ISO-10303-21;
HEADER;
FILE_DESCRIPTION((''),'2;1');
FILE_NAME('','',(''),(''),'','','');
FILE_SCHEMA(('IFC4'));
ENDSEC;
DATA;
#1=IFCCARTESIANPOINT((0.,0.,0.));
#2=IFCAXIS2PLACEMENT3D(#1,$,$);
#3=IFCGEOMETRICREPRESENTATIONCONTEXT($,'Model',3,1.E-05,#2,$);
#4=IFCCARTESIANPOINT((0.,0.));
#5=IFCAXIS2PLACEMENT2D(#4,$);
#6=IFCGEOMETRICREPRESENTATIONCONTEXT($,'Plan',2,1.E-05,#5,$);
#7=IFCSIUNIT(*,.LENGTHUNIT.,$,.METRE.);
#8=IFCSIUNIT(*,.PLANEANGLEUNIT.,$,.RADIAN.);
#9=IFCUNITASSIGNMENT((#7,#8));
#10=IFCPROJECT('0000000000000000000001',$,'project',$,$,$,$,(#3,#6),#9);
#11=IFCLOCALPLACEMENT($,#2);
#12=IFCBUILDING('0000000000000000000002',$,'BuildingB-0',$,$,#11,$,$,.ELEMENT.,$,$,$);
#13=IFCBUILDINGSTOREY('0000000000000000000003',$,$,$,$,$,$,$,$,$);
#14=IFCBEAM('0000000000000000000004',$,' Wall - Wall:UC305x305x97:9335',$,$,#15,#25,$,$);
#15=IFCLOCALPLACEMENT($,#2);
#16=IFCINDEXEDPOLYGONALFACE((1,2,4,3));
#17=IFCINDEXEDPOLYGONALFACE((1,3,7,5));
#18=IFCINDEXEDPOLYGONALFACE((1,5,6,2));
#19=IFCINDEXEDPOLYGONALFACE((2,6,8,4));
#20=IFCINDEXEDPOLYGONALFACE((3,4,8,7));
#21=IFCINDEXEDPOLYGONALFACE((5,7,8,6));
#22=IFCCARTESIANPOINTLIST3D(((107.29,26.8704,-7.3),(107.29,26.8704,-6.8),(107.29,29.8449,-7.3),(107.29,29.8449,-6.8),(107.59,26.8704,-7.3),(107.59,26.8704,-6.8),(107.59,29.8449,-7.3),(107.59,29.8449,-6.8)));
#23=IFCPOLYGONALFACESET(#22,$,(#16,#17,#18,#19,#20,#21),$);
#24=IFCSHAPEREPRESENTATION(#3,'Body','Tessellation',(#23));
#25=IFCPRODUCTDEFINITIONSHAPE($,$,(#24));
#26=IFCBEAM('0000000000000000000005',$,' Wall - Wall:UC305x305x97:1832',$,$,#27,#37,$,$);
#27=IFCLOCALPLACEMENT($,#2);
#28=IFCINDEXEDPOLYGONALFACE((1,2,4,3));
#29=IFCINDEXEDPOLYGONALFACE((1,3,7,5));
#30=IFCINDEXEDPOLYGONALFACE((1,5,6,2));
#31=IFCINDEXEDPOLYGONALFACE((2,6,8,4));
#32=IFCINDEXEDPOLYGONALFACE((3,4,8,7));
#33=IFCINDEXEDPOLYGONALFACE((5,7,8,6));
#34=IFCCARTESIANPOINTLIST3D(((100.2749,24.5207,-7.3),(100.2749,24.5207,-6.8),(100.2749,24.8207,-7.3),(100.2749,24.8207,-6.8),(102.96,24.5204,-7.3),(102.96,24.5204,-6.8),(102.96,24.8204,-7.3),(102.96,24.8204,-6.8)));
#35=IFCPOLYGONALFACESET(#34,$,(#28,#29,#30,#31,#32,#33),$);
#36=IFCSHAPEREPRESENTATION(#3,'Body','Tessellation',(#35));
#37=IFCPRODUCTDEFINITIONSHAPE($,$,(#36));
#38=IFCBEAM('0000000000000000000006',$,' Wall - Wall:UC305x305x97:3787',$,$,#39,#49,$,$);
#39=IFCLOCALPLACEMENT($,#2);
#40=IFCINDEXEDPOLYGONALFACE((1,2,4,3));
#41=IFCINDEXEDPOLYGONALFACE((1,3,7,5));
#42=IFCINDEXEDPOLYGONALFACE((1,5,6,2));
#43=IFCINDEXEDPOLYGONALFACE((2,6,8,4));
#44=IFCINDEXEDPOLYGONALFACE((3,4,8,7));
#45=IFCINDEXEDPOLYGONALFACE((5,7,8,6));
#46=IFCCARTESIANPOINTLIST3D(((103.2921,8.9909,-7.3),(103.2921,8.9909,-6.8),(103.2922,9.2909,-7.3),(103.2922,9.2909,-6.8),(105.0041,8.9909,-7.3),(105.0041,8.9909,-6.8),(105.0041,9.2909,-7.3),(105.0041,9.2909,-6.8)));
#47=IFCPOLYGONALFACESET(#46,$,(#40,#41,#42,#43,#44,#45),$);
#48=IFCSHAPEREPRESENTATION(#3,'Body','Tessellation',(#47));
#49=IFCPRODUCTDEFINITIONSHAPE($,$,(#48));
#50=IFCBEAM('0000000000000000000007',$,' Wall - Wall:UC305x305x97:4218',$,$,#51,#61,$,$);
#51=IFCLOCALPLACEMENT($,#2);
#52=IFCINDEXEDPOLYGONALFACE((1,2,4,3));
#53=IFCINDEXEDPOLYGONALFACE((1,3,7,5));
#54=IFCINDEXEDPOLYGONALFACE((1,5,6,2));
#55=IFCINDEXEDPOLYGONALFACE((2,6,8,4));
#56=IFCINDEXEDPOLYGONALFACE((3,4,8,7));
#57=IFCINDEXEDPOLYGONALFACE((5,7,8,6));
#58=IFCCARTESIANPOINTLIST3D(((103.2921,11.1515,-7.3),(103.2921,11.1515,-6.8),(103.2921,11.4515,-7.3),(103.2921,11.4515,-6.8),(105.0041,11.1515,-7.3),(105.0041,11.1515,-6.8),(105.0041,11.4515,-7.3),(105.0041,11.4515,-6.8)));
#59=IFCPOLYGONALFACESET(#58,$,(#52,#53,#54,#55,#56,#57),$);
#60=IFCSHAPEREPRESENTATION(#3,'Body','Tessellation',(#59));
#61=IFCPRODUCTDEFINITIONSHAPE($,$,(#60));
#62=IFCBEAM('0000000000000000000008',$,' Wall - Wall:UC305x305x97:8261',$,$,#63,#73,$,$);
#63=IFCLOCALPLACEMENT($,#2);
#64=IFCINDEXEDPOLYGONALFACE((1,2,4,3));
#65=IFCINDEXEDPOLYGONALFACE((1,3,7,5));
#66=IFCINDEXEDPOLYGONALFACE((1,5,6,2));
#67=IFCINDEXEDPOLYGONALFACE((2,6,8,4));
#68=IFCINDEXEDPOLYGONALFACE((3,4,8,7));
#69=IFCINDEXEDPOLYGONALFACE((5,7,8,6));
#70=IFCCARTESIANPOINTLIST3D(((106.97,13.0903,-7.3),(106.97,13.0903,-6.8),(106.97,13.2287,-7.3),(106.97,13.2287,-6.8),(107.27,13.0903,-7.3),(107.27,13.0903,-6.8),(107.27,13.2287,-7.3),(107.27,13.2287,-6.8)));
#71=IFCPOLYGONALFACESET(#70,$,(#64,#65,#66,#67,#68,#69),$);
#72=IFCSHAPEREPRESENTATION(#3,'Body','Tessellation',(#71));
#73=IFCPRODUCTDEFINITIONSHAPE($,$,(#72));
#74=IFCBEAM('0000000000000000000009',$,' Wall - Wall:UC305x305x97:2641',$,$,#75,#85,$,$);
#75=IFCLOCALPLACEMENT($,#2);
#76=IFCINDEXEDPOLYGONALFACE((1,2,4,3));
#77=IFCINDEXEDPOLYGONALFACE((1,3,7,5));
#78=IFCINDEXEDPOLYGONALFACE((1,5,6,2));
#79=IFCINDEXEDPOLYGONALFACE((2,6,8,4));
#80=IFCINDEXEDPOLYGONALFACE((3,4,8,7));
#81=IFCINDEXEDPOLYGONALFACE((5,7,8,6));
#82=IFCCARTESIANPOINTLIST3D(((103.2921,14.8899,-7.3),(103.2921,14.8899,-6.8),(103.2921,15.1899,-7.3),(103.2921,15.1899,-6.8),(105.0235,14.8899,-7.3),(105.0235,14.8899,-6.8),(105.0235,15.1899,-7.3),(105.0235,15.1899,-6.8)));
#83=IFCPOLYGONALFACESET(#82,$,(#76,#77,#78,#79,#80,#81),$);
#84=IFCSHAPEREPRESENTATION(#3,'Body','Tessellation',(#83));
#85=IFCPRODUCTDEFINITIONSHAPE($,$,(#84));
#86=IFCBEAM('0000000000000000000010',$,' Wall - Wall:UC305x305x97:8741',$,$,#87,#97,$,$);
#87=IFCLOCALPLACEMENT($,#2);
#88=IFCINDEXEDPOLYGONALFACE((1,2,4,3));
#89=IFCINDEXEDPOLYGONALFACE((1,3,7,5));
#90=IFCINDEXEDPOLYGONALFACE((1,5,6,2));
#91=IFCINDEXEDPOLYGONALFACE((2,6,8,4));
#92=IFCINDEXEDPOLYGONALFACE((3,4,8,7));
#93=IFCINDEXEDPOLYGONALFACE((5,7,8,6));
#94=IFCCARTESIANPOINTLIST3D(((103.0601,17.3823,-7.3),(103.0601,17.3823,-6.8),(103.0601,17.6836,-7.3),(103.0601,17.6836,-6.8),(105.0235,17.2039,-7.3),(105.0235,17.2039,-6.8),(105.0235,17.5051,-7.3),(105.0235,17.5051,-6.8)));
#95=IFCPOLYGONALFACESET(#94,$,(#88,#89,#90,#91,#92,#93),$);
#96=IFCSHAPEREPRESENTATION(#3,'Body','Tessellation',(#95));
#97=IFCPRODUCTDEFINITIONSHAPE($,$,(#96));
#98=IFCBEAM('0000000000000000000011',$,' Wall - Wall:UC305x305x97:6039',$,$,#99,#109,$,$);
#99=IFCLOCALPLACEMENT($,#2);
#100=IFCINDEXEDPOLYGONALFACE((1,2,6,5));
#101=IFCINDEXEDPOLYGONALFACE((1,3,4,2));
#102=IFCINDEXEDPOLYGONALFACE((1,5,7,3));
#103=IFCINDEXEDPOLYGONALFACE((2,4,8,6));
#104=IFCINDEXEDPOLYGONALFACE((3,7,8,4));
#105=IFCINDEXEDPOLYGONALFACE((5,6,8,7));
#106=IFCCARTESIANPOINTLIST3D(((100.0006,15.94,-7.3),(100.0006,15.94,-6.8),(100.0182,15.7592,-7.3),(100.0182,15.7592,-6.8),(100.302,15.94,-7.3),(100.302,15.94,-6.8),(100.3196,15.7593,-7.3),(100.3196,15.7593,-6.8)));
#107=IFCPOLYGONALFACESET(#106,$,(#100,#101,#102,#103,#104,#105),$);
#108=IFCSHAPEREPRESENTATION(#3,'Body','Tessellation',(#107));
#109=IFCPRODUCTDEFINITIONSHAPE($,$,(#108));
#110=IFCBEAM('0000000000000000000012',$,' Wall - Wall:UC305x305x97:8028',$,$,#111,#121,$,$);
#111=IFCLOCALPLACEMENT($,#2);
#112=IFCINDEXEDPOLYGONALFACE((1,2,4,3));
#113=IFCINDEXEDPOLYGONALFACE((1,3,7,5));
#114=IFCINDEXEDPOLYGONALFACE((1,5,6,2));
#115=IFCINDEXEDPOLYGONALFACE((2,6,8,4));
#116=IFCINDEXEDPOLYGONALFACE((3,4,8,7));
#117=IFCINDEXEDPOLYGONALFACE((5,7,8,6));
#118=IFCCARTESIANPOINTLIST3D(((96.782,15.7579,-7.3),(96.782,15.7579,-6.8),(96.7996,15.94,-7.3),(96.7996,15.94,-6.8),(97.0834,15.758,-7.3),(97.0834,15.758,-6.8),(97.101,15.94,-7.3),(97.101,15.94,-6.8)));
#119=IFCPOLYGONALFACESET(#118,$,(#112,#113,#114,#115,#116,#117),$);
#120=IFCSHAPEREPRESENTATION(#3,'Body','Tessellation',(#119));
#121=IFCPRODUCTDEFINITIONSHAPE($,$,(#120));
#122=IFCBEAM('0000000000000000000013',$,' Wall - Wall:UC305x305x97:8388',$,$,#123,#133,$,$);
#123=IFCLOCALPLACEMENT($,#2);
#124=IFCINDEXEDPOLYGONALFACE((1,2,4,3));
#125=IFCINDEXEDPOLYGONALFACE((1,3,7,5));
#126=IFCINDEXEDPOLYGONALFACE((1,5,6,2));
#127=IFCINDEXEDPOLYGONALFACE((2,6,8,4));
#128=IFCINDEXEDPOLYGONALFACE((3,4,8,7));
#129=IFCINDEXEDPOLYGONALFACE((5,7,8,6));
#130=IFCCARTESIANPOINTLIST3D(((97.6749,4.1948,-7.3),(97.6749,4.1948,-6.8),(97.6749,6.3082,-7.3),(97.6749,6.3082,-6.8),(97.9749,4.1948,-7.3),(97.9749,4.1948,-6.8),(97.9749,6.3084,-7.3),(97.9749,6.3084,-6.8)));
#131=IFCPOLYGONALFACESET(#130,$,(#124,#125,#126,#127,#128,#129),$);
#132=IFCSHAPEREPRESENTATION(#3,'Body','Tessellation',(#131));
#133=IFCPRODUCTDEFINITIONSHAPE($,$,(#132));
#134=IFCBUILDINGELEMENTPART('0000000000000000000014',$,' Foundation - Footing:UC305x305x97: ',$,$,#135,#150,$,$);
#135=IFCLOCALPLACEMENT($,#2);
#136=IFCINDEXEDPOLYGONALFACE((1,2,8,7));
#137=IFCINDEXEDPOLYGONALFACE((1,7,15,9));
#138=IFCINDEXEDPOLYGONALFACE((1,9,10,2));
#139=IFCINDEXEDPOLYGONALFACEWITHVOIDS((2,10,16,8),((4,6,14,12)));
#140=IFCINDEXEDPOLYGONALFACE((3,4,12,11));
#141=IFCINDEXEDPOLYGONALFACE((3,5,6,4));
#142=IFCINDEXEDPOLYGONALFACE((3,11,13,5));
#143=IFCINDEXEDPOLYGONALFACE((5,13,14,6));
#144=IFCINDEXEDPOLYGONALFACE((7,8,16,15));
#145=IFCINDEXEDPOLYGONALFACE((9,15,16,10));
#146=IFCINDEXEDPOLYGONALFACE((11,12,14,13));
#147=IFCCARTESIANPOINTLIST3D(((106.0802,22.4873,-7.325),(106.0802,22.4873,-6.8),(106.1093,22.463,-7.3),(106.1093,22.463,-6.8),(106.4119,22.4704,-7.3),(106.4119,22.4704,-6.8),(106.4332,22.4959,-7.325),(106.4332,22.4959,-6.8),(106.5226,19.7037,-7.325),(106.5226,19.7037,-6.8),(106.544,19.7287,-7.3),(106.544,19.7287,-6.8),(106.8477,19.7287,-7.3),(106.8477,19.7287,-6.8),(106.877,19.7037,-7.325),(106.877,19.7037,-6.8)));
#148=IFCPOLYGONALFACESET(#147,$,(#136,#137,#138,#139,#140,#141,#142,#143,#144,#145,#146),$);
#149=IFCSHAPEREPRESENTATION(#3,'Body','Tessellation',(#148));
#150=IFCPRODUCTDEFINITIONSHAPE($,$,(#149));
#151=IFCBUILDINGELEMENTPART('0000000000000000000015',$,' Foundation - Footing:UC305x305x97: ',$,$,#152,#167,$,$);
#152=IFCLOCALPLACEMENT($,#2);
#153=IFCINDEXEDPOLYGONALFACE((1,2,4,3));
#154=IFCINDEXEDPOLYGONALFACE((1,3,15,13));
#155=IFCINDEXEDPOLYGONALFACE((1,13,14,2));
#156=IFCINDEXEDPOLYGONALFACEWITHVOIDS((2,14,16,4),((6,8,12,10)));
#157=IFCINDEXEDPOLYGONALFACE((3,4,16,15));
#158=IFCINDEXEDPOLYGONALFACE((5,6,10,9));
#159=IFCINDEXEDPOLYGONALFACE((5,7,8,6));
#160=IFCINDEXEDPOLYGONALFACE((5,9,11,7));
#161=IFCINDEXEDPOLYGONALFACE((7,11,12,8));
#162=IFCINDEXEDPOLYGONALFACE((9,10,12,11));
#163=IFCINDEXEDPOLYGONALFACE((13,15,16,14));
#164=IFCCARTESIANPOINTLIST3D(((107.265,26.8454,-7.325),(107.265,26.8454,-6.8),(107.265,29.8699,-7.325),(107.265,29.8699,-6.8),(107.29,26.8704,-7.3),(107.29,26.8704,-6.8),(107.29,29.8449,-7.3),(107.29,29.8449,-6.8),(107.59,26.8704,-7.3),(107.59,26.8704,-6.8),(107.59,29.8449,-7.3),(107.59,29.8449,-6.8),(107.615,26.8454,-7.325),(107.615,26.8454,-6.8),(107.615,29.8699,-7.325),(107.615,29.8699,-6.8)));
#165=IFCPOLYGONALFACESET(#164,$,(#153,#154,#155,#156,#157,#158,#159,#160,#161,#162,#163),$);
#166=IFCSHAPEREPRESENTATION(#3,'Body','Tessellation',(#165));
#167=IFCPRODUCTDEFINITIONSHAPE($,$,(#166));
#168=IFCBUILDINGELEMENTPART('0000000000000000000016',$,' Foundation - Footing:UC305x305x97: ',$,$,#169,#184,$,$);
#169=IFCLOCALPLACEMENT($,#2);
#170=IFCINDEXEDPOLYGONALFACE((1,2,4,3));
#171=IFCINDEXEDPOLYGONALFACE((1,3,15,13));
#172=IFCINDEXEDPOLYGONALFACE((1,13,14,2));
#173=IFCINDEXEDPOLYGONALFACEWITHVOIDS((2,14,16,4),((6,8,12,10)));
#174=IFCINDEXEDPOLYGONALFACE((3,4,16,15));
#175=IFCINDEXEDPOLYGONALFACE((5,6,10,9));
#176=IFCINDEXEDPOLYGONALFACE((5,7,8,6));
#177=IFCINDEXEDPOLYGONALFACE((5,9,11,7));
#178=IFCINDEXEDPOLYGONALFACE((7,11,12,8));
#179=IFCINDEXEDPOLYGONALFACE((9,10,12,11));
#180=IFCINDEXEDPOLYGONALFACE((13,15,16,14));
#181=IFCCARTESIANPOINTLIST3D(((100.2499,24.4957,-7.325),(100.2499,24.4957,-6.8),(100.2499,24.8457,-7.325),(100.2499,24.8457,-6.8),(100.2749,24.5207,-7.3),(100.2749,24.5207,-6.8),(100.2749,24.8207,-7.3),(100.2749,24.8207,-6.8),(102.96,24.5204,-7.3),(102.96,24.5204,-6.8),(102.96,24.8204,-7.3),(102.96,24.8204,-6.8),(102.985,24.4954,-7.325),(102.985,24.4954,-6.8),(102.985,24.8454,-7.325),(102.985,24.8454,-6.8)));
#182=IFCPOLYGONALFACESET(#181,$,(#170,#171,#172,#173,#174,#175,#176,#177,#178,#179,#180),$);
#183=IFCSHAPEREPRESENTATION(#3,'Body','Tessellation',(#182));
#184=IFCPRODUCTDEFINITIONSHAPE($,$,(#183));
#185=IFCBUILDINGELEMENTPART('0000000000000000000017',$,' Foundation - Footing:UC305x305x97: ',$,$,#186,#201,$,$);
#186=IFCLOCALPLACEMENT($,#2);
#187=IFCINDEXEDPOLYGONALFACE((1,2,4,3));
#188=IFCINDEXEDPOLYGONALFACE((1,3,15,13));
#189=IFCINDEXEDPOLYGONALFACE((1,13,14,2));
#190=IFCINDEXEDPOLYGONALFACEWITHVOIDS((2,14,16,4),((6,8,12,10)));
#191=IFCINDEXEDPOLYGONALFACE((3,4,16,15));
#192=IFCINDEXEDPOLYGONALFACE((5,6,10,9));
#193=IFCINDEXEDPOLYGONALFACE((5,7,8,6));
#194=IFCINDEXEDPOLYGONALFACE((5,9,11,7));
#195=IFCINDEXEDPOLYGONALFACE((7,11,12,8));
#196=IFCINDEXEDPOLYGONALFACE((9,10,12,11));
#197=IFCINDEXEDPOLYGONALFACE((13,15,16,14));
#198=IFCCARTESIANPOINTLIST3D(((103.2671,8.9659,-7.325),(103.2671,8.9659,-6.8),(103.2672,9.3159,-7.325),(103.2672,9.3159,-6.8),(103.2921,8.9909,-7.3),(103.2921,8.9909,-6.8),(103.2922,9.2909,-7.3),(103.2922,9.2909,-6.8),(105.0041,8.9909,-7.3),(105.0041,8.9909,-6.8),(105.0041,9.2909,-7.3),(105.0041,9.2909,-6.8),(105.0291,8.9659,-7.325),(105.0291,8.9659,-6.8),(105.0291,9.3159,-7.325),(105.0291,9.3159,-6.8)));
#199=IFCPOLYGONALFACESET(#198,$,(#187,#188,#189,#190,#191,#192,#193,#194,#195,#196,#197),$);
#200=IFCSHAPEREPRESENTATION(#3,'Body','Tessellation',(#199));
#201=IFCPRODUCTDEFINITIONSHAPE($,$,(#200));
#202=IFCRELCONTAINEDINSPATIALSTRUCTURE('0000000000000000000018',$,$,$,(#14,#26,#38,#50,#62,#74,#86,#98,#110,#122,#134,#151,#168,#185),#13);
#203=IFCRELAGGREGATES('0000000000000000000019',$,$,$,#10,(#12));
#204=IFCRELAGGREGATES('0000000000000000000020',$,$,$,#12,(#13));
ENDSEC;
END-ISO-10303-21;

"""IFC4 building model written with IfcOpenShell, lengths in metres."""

from ifc_helpers import new_model, si_unit, origin, origin_2d, place, context, project, spatial, polyline, outline, extrude, element, save


model = new_model("IFC4")

# Units and contexts
model_context = context("Model", 3, precision=1e-05, world=origin())
plan_context = context("Plan", 2, precision=1e-05, world=origin_2d())
ifc_project = project(units=[si_unit("LENGTHUNIT", "METRE"), si_unit("PLANEANGLEUNIT", "RADIAN")], contexts=[model_context, plan_context])

# Building, storey
building_placement = place(None, origin())
building = spatial("IfcBuilding", under=ifc_project, at=building_placement, Name="BuildingB-0", CompositionType="ELEMENT")
storey = spatial("IfcBuildingStorey", under=building)

# Beams
element("IfcBeam", 1, inside=storey, Name=" Wall - Wall:UC305x305x97:9335", context=model_context, shape_type="SweptSolid", body=[
    extrude(outline(polyline([(107.29, 26.8704, -7.3), (107.59, 26.8704, -7.3), (107.59, 29.8449, -7.3), (107.29, 29.8449, -7.3), (107.29, 26.8704, -7.3)])), None, (0.0, 0.0, 1.0), 0.5),
])
element("IfcBeam", 2, inside=storey, Name=" Wall - Wall:UC305x305x97:1832", context=model_context, shape_type="SweptSolid", body=[
    extrude(outline(polyline([(102.96, 24.5204, -7.3), (102.96, 24.8204, -7.3), (100.2749, 24.8207, -7.3), (100.2749, 24.5207, -7.3), (102.96, 24.5204, -7.3)])), None, (0.0, 0.0, 1.0), 0.5),
])
element("IfcBeam", 3, inside=storey, Name=" Wall - Wall:UC305x305x97:3787", context=model_context, shape_type="SweptSolid", body=[
    extrude(outline(polyline([(105.0041, 8.9909, -7.3), (105.0041, 9.2909, -7.3), (103.2922, 9.2909, -7.3), (103.2921, 8.9909, -7.3), (105.0041, 8.9909, -7.3)])), None, (0.0, 0.0, 1.0), 0.5),
])
element("IfcBeam", 4, inside=storey, Name=" Wall - Wall:UC305x305x97:4218", context=model_context, shape_type="SweptSolid", body=[
    extrude(outline(polyline([(105.0041, 11.1515, -7.3), (105.0041, 11.4515, -7.3), (103.2921, 11.4515, -7.3), (103.2921, 11.1515, -7.3), (105.0041, 11.1515, -7.3)])), None, (0.0, 0.0, 1.0), 0.5),
])
element("IfcBeam", 5, inside=storey, Name=" Wall - Wall:UC305x305x97:8261", context=model_context, shape_type="SweptSolid", body=[
    extrude(outline(polyline([(107.27, 13.0903, -7.3), (107.27, 13.2287, -7.3), (106.97, 13.2287, -7.3), (106.97, 13.0903, -7.3), (107.27, 13.0903, -7.3)])), None, (0.0, 0.0, 1.0), 0.5),
])
element("IfcBeam", 6, inside=storey, Name=" Wall - Wall:UC305x305x97:2641", context=model_context, shape_type="SweptSolid", body=[
    extrude(outline(polyline([(105.0235, 14.8899, -7.3), (105.0235, 15.1899, -7.3), (103.2921, 15.1899, -7.3), (103.2921, 14.8899, -7.3), (105.0235, 14.8899, -7.3)])), None, (0.0, 0.0, 1.0), 0.5),
])
element("IfcBeam", 7, inside=storey, Name=" Wall - Wall:UC305x305x97:8741", context=model_context, shape_type="SweptSolid", body=[
    extrude(outline(polyline([(105.0235, 17.2039, -7.3), (105.0235, 17.5051, -7.3), (103.0601, 17.6836, -7.3), (103.0601, 17.3823, -7.3), (105.0235, 17.2039, -7.3)])), None, (0.0, 0.0, 1.0), 0.5),
])
element("IfcBeam", 8, inside=storey, Name=" Wall - Wall:UC305x305x97:6039", context=model_context, shape_type="SweptSolid", body=[
    extrude(outline(polyline([(100.3196, 15.7593, -7.3), (100.302, 15.94, -7.3), (100.0006, 15.94, -7.3), (100.0182, 15.7592, -7.3), (100.3196, 15.7593, -7.3)])), None, (0.0, 0.0, 1.0), 0.5),
])
element("IfcBeam", 9, inside=storey, Name=" Wall - Wall:UC305x305x97:8028", context=model_context, shape_type="SweptSolid", body=[
    extrude(outline(polyline([(97.0834, 15.758, -7.3), (97.101, 15.94, -7.3), (96.7996, 15.94, -7.3), (96.782, 15.7579, -7.3), (97.0834, 15.758, -7.3)])), None, (0.0, 0.0, 1.0), 0.5),
])
element("IfcBeam", 10, inside=storey, Name=" Wall - Wall:UC305x305x97:8388", context=model_context, shape_type="SweptSolid", body=[
    extrude(outline(polyline([(97.9749, 4.1948, -7.3), (97.9749, 6.3084, -7.3), (97.6749, 6.3082, -7.3), (97.6749, 4.1948, -7.3), (97.9749, 4.1948, -7.3)])), None, (0.0, 0.0, 1.0), 0.5),
])

# Building element parts, openings
building_element_part_1 = element("IfcBuildingElementPart", 11, inside=storey, Name=" Foundation - Footing:UC305x305x97: ", context=model_context, shape_type="SweptSolid", body=[
    extrude(outline(polyline([(106.5226, 19.7037, -7.325), (106.877, 19.7037, -7.325), (106.4332, 22.4959, -7.325), (106.0802, 22.4873, -7.325), (106.5226, 19.7037, -7.325)])), None, (0.0, 0.0, 1.0), 0.525),
])
element("IfcOpeningElement", 12, inside=storey, cuts=building_element_part_1, context=model_context, shape_type="SweptSolid", body=[
    extrude(outline(polyline([(106.544, 19.7287, -7.3), (106.8477, 19.7287, -7.3), (106.4119, 22.4704, -7.3), (106.1093, 22.463, -7.3), (106.544, 19.7287, -7.3)])), None, (0.0, 0.0, 1.0), 0.5),
])
building_element_part_2 = element("IfcBuildingElementPart", 13, inside=storey, Name=" Foundation - Footing:UC305x305x97: ", context=model_context, shape_type="SweptSolid", body=[
    extrude(outline(polyline([(107.265, 26.8454, -7.325), (107.615, 26.8454, -7.325), (107.615, 29.8699, -7.325), (107.265, 29.8699, -7.325), (107.265, 26.8454, -7.325)])), None, (0.0, 0.0, 1.0), 0.525),
])
element("IfcOpeningElement", 14, inside=storey, cuts=building_element_part_2, context=model_context, shape_type="SweptSolid", body=[
    extrude(outline(polyline([(107.29, 26.8704, -7.3), (107.59, 26.8704, -7.3), (107.59, 29.8449, -7.3), (107.29, 29.8449, -7.3), (107.29, 26.8704, -7.3)])), None, (0.0, 0.0, 1.0), 0.5),
])
building_element_part_3 = element("IfcBuildingElementPart", 15, inside=storey, Name=" Foundation - Footing:UC305x305x97: ", context=model_context, shape_type="SweptSolid", body=[
    extrude(outline(polyline([(102.985, 24.4954, -7.325), (102.985, 24.8454, -7.325), (100.2499, 24.8457, -7.325), (100.2499, 24.4957, -7.325), (102.985, 24.4954, -7.325)])), None, (0.0, 0.0, 1.0), 0.525),
])
element("IfcOpeningElement", 16, inside=storey, cuts=building_element_part_3, context=model_context, shape_type="SweptSolid", body=[
    extrude(outline(polyline([(102.96, 24.5204, -7.3), (102.96, 24.8204, -7.3), (100.2749, 24.8207, -7.3), (100.2749, 24.5207, -7.3), (102.96, 24.5204, -7.3)])), None, (0.0, 0.0, 1.0), 0.5),
])
building_element_part_4 = element("IfcBuildingElementPart", 17, inside=storey, Name=" Foundation - Footing:UC305x305x97: ", context=model_context, shape_type="SweptSolid", body=[
    extrude(outline(polyline([(105.0291, 8.9659, -7.325), (105.0291, 9.3159, -7.325), (103.2672, 9.3159, -7.325), (103.2671, 8.9659, -7.325), (105.0291, 8.9659, -7.325)])), None, (0.0, 0.0, 1.0), 0.525),
])
element("IfcOpeningElement", 18, inside=storey, cuts=building_element_part_4, context=model_context, shape_type="SweptSolid", body=[
    extrude(outline(polyline([(105.0041, 8.9909, -7.3), (105.0041, 9.2909, -7.3), (103.2922, 9.2909, -7.3), (103.2921, 8.9909, -7.3), (105.0041, 8.9909, -7.3)])), None, (0.0, 0.0, 1.0), 0.5),
])

save(model, "model.ifc")
